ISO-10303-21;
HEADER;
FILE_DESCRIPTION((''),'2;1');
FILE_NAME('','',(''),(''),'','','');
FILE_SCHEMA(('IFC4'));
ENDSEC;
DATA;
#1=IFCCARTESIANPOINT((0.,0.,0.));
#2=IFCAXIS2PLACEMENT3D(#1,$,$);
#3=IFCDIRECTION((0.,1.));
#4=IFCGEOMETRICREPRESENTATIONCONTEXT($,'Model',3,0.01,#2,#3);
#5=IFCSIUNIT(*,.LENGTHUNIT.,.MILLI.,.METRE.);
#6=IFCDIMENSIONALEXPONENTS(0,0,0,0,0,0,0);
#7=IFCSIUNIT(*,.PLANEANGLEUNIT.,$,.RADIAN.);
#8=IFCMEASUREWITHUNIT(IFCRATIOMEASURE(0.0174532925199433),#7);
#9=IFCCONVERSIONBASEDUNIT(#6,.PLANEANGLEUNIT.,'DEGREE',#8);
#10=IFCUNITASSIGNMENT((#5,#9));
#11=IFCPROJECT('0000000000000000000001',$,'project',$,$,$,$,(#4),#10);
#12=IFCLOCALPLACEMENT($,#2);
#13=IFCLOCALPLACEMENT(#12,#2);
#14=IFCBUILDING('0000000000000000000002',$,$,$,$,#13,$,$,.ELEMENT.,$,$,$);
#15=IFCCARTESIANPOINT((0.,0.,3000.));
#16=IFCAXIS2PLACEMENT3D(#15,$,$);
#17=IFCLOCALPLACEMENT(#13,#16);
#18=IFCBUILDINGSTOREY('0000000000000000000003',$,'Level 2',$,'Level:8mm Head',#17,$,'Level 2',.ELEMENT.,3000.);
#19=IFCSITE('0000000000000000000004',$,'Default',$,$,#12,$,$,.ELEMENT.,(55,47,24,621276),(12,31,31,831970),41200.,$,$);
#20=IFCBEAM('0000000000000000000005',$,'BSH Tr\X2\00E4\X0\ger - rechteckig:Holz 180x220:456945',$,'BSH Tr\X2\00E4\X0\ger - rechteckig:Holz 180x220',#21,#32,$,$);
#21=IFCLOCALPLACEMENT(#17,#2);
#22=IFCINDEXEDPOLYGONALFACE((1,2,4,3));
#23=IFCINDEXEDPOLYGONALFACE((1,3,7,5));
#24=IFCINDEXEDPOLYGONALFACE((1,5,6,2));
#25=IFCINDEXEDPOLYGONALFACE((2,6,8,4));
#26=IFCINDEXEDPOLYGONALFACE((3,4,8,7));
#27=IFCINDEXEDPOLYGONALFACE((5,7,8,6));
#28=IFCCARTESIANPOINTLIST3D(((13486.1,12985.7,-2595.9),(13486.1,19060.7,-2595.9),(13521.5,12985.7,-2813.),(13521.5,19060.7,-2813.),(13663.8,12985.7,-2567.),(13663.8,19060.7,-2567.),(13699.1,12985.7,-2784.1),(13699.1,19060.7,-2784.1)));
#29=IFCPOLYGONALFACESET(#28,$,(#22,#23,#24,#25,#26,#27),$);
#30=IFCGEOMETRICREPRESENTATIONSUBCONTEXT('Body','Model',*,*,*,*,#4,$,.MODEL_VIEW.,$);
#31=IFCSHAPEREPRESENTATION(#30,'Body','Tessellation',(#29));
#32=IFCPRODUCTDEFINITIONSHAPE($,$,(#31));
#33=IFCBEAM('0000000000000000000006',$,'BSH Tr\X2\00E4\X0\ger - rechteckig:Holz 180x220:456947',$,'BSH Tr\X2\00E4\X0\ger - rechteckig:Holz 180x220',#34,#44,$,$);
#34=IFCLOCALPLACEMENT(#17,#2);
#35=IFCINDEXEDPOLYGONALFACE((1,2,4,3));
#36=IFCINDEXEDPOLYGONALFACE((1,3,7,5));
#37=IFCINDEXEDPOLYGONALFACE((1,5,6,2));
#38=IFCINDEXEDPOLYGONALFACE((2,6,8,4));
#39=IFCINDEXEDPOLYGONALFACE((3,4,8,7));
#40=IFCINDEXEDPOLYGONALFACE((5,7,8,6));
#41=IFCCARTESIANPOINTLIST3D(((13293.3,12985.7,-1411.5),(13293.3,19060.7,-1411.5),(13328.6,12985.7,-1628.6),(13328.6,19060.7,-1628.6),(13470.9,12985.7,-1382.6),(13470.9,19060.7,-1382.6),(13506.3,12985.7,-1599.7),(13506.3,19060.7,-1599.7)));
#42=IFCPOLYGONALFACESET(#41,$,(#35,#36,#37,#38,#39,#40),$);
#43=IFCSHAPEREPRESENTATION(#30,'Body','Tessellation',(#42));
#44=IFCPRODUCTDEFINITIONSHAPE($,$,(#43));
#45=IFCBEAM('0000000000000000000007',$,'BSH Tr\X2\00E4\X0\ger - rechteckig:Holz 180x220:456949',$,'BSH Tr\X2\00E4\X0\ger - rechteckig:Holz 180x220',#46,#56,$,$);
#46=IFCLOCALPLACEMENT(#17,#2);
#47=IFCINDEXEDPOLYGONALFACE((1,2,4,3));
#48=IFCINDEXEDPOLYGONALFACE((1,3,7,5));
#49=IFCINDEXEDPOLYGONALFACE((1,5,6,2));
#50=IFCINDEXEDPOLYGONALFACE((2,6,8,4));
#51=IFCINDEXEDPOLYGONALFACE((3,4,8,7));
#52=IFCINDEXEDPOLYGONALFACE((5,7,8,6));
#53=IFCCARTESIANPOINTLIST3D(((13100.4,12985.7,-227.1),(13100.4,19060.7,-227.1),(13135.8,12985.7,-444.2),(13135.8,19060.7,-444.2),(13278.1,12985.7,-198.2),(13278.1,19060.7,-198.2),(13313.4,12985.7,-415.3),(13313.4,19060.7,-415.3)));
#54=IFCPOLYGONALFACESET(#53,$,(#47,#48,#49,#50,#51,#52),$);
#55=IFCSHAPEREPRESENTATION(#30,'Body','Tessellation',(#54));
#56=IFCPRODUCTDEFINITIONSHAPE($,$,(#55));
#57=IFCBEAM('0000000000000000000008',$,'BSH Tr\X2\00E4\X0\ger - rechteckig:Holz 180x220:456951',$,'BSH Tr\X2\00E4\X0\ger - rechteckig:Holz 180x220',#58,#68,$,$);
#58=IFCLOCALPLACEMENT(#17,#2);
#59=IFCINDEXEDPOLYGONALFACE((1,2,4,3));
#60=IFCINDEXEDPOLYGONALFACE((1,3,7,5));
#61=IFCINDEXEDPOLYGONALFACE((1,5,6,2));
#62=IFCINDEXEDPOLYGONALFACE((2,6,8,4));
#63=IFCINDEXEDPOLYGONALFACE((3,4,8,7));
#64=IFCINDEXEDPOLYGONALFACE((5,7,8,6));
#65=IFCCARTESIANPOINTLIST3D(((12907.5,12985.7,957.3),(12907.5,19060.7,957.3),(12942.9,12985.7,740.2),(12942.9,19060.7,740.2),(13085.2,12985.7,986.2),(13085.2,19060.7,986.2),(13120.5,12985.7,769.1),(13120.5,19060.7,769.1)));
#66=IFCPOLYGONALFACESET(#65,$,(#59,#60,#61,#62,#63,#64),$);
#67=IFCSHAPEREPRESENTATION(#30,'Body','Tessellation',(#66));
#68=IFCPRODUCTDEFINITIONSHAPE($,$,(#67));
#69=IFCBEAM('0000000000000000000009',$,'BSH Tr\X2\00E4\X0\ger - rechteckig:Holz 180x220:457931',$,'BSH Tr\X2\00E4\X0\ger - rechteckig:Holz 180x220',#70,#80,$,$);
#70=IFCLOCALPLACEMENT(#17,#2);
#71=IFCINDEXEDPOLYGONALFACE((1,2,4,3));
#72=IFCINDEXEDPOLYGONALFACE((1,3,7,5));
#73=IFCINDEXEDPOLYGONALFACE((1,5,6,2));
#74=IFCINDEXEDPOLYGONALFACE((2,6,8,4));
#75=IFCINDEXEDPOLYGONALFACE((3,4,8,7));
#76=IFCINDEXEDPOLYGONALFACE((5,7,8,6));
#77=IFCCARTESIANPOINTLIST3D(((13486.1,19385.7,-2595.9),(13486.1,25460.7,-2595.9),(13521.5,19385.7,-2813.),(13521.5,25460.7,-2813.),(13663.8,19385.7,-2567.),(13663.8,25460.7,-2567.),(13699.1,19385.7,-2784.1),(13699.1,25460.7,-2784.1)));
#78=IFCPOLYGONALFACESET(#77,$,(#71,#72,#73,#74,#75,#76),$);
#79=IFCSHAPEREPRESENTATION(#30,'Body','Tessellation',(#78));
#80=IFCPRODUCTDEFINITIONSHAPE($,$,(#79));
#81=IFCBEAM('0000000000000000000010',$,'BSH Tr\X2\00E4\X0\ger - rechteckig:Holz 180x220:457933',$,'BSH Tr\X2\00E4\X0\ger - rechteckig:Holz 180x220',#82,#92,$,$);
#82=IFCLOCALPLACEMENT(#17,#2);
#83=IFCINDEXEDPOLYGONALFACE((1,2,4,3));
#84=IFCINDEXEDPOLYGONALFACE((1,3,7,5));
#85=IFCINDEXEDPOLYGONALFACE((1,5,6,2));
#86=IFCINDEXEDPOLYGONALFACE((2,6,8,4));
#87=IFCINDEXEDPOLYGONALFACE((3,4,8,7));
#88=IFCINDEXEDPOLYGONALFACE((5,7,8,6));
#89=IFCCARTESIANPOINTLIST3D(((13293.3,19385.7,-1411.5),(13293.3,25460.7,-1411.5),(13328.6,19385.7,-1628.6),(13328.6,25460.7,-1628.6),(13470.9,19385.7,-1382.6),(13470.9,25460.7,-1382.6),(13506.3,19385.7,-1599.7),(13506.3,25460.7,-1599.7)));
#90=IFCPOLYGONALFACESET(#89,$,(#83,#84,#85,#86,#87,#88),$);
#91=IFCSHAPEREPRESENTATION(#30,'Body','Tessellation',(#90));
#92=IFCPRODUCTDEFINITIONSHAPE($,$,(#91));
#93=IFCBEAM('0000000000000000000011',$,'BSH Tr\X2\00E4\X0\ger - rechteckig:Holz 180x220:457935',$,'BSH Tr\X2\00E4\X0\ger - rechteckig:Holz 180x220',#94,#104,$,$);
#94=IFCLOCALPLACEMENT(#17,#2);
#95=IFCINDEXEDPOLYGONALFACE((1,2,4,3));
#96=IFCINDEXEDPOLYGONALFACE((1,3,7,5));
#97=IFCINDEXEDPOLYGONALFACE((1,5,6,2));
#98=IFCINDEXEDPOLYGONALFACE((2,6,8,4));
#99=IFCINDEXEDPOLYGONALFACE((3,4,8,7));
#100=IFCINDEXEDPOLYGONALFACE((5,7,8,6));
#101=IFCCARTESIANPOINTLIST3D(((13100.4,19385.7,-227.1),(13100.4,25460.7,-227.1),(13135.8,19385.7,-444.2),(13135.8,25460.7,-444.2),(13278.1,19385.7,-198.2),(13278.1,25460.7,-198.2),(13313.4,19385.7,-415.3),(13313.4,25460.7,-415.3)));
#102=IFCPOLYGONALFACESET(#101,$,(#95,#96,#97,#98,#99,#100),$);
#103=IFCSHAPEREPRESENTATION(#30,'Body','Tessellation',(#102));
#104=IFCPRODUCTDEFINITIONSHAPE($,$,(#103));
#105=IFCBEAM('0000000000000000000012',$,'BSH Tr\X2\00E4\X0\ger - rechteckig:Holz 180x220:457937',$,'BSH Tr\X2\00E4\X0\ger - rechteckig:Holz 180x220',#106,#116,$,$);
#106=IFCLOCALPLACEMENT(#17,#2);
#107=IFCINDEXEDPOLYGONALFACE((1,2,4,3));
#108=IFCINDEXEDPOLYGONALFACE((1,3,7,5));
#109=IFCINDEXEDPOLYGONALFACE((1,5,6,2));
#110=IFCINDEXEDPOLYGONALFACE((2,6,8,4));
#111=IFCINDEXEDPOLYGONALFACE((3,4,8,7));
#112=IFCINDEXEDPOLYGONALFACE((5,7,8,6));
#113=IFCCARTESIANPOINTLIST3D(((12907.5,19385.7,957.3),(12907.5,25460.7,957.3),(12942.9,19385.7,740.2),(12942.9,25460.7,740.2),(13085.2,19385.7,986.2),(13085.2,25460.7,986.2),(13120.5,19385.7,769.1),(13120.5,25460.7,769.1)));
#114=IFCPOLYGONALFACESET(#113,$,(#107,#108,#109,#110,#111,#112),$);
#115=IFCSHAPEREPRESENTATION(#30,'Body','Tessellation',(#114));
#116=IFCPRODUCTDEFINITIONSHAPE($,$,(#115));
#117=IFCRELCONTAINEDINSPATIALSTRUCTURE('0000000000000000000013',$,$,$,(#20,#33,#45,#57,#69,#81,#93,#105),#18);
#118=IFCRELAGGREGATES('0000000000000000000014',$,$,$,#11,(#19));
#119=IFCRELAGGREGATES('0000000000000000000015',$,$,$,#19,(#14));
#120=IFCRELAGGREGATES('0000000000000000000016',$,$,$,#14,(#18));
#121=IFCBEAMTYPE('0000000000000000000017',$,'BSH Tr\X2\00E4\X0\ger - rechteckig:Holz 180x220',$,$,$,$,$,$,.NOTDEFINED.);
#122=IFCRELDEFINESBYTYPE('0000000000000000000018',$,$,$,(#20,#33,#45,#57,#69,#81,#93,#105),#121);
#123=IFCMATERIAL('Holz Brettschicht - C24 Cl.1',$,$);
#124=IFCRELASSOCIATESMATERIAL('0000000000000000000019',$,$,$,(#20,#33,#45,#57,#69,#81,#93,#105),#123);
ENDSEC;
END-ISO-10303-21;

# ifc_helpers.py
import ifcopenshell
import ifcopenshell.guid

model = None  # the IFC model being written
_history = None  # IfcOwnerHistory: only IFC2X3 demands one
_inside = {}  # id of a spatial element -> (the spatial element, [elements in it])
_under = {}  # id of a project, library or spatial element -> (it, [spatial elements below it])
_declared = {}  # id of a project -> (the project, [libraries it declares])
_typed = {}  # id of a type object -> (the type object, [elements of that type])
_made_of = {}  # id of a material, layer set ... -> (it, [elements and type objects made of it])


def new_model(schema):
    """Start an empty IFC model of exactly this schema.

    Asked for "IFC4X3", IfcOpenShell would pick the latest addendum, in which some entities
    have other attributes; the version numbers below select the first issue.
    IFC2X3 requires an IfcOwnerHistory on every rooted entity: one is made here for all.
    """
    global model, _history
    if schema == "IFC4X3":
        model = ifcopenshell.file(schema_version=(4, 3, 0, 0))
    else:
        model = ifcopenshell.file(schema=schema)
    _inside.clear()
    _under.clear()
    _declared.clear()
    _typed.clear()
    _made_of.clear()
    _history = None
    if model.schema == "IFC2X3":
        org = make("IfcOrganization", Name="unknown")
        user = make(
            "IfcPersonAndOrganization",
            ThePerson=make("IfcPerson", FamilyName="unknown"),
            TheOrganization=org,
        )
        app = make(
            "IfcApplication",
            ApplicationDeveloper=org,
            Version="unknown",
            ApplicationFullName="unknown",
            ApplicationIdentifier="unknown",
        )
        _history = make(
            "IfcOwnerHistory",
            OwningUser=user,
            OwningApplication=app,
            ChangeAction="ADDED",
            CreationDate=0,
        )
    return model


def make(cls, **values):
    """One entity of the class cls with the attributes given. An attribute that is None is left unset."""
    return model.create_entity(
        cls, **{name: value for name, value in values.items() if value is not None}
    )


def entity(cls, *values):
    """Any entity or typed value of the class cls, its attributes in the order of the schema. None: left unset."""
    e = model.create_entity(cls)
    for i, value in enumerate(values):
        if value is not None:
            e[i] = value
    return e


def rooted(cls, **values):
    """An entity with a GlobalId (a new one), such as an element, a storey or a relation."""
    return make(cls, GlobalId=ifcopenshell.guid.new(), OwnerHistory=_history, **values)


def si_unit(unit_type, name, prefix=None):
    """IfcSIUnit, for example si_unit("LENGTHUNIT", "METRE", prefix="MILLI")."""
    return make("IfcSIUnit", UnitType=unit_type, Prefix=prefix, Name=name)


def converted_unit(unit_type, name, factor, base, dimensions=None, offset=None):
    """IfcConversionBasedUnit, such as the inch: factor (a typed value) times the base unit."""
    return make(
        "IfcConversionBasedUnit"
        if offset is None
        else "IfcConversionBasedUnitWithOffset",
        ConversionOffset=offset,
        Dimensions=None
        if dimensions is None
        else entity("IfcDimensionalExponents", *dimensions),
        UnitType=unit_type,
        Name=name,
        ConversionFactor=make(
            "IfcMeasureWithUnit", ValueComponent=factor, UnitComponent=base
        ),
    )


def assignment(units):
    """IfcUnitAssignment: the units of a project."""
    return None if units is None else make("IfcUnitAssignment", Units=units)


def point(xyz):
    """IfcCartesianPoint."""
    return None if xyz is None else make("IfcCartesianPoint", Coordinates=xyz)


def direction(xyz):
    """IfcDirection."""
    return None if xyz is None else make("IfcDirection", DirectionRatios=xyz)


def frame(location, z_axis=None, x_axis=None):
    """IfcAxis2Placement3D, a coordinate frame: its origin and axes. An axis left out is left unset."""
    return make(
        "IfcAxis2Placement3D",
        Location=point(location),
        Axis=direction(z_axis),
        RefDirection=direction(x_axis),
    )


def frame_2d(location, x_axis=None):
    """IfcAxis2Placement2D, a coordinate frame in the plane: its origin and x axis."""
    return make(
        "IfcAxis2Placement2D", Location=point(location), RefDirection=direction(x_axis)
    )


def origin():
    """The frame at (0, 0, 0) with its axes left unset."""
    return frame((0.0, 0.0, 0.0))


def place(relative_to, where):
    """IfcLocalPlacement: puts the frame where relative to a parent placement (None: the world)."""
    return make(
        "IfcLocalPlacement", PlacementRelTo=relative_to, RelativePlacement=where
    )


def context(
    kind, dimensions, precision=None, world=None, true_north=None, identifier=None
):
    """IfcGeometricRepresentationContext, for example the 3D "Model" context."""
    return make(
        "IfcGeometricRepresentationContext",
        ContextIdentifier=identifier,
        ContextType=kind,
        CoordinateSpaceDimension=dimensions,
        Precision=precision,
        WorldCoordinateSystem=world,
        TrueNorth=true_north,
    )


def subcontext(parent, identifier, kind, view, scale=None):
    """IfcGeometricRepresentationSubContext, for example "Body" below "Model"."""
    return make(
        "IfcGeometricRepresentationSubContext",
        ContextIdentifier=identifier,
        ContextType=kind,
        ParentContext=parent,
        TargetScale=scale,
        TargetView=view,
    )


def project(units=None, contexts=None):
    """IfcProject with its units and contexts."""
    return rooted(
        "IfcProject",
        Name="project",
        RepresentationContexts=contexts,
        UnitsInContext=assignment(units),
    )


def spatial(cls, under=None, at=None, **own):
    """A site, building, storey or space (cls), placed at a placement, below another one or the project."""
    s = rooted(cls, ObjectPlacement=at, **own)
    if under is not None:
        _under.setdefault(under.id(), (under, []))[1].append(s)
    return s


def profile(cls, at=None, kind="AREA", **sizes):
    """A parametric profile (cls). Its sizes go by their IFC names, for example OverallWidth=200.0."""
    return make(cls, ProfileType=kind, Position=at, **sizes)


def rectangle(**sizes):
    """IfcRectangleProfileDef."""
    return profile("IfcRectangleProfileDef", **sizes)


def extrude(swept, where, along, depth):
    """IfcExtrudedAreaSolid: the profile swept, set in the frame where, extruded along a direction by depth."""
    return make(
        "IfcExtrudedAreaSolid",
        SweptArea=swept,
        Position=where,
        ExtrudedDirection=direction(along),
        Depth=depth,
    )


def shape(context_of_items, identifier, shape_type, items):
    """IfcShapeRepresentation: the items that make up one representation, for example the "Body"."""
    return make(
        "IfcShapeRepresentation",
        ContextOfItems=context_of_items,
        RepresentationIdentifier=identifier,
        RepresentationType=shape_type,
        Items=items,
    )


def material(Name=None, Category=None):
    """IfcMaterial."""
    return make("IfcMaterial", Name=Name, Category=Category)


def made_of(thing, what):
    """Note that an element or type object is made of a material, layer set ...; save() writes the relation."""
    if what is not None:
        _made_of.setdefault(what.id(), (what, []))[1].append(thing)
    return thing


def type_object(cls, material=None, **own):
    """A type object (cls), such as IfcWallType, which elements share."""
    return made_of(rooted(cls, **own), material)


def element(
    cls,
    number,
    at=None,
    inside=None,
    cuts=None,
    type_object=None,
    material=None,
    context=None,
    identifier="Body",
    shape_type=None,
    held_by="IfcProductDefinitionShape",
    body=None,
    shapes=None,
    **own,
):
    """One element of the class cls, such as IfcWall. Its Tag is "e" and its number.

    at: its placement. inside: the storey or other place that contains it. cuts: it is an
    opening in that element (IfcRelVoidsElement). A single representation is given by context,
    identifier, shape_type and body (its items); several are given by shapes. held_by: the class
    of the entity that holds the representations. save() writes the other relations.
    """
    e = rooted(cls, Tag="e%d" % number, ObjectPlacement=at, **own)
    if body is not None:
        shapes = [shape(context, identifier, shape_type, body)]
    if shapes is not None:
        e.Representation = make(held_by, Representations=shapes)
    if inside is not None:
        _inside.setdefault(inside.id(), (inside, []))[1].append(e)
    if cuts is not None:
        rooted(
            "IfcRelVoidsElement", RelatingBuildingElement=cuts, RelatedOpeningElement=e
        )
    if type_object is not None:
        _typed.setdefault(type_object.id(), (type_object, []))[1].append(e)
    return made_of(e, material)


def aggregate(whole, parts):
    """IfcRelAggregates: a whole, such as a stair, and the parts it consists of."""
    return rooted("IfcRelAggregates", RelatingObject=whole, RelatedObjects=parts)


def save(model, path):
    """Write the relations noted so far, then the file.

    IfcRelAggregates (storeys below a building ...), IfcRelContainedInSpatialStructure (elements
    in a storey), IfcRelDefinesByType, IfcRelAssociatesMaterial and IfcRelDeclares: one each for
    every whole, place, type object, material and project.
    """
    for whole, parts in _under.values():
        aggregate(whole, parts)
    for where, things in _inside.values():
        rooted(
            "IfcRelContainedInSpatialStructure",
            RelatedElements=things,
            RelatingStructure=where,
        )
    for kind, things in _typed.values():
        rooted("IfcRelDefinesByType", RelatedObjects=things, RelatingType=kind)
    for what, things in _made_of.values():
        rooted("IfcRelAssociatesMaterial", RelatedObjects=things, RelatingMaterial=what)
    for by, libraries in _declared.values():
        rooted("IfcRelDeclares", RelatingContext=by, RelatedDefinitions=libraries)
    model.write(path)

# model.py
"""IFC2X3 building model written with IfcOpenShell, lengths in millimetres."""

from ifc_helpers import new_model, entity, si_unit, converted_unit, direction, frame, frame_2d, origin, place, context, subcontext, project, spatial, rectangle, extrude, material, type_object, element, save


model = new_model("IFC2X3")

# Units and contexts
model_context = context("Model", 3, precision=0.01, world=origin(), true_north=direction((0.0, 1.0)))
body_context = subcontext(model_context, "Body", "Model", "MODEL_VIEW")
ifc_project = project(units=[si_unit("LENGTHUNIT", "METRE", prefix="MILLI"), converted_unit("PLANEANGLEUNIT", "DEGREE", entity("IfcRatioMeasure", 0.0174532925199433), si_unit("PLANEANGLEUNIT", "RADIAN"), dimensions=[0, 0, 0, 0, 0, 0, 0])], contexts=[model_context])

# Site, building, storey
site_placement = place(None, origin())
site = spatial("IfcSite", under=ifc_project, at=site_placement, Name="Default", CompositionType="ELEMENT", RefLatitude=(55, 47, 24, 621276), RefLongitude=(12, 31, 31, 831970), RefElevation=41200.0)
building_placement = place(site_placement, origin())
building = spatial("IfcBuilding", under=site, at=building_placement, CompositionType="ELEMENT")
storey_placement = place(building_placement, frame((0.0, 0.0, 3000.0)))
storey = spatial("IfcBuildingStorey", under=building, at=storey_placement, Name="Level 2", ObjectType="Level:8mm Head", LongName="Level 2", CompositionType="ELEMENT", Elevation=3000.0)

# Beams
ifc_material = material(Name="Holz Brettschicht - C24 Cl.1")
beam_type_1 = type_object("IfcBeamType", Name="BSH Träger - rechteckig:Holz 180x220", PredefinedType="NOTDEFINED")
beam_1_placement = place(storey_placement, frame((13681.5, 13723.2, -2675.5), z_axis=(0.0, 0.0, 1.0), x_axis=(0.0, 1.0, 0.0)))
element("IfcBeam", 1, at=beam_1_placement, inside=storey, type_object=beam_type_1, material=ifc_material, Name="BSH Träger - rechteckig:Holz 180x220:456945", ObjectType="BSH Träger - rechteckig:Holz 180x220", context=body_context, shape_type="SweptSolid", body=[
    extrude(rectangle(XDim=220.0, YDim=180.0, at=frame_2d((0.0, 0.0), x_axis=(1.0, 0.0))), frame((-737.5, 88.8, -14.5), z_axis=(1.0, 0.0, 0.0), x_axis=(0.0, 0.160724, 0.986999)), (0.0, 0.0, 1.0), 6075.0),
])
beam_2_placement = place(storey_placement, frame((13488.6, 13723.2, -1491.1), z_axis=(0.0, 0.0, 1.0), x_axis=(0.0, 1.0, 0.0)))
element("IfcBeam", 2, at=beam_2_placement, inside=storey, type_object=beam_type_1, material=ifc_material, Name="BSH Träger - rechteckig:Holz 180x220:456947", ObjectType="BSH Träger - rechteckig:Holz 180x220", context=body_context, shape_type="SweptSolid", body=[
    extrude(rectangle(XDim=220.0, YDim=180.0, at=frame_2d((0.0, 0.0), x_axis=(1.0, 0.0))), frame((-737.5, 88.8, -14.5), z_axis=(1.0, 0.0, 0.0), x_axis=(0.0, 0.160724, 0.986999)), (0.0, 0.0, 1.0), 6075.0),
])
beam_3_placement = place(storey_placement, frame((13295.7, 13723.2, -306.7), z_axis=(0.0, 0.0, 1.0), x_axis=(0.0, 1.0, 0.0)))
element("IfcBeam", 3, at=beam_3_placement, inside=storey, type_object=beam_type_1, material=ifc_material, Name="BSH Träger - rechteckig:Holz 180x220:456949", ObjectType="BSH Träger - rechteckig:Holz 180x220", context=body_context, shape_type="SweptSolid", body=[
    extrude(rectangle(XDim=220.0, YDim=180.0, at=frame_2d((0.0, 0.0), x_axis=(1.0, 0.0))), frame((-737.5, 88.8, -14.5), z_axis=(1.0, 0.0, 0.0), x_axis=(0.0, 0.160724, 0.986999)), (0.0, 0.0, 1.0), 6075.0),
])
beam_4_placement = place(storey_placement, frame((13102.9, 13723.2, 877.7), z_axis=(0.0, 0.0, 1.0), x_axis=(0.0, 1.0, 0.0)))
element("IfcBeam", 4, at=beam_4_placement, inside=storey, type_object=beam_type_1, material=ifc_material, Name="BSH Träger - rechteckig:Holz 180x220:456951", ObjectType="BSH Träger - rechteckig:Holz 180x220", context=body_context, shape_type="SweptSolid", body=[
    extrude(rectangle(XDim=220.0, YDim=180.0, at=frame_2d((0.0, 0.0), x_axis=(1.0, 0.0))), frame((-737.5, 88.8, -14.5), z_axis=(1.0, 0.0, 0.0), x_axis=(0.0, 0.160724, 0.986999)), (0.0, 0.0, 1.0), 6075.0),
])
beam_5_placement = place(storey_placement, frame((13681.5, 20123.2, -2675.5), z_axis=(0.0, 0.0, 1.0), x_axis=(0.0, 1.0, 0.0)))
element("IfcBeam", 5, at=beam_5_placement, inside=storey, type_object=beam_type_1, material=ifc_material, Name="BSH Träger - rechteckig:Holz 180x220:457931", ObjectType="BSH Träger - rechteckig:Holz 180x220", context=body_context, shape_type="SweptSolid", body=[
    extrude(rectangle(XDim=220.0, YDim=180.0, at=frame_2d((0.0, 0.0), x_axis=(1.0, 0.0))), frame((-737.5, 88.8, -14.5), z_axis=(1.0, 0.0, 0.0), x_axis=(0.0, 0.160724, 0.986999)), (0.0, 0.0, 1.0), 6075.0),
])
beam_6_placement = place(storey_placement, frame((13488.6, 20123.2, -1491.1), z_axis=(0.0, 0.0, 1.0), x_axis=(0.0, 1.0, 0.0)))
element("IfcBeam", 6, at=beam_6_placement, inside=storey, type_object=beam_type_1, material=ifc_material, Name="BSH Träger - rechteckig:Holz 180x220:457933", ObjectType="BSH Träger - rechteckig:Holz 180x220", context=body_context, shape_type="SweptSolid", body=[
    extrude(rectangle(XDim=220.0, YDim=180.0, at=frame_2d((0.0, 0.0), x_axis=(1.0, 0.0))), frame((-737.5, 88.8, -14.5), z_axis=(1.0, 0.0, 0.0), x_axis=(0.0, 0.160724, 0.986999)), (0.0, 0.0, 1.0), 6075.0),
])
beam_7_placement = place(storey_placement, frame((13295.7, 20123.2, -306.7), z_axis=(0.0, 0.0, 1.0), x_axis=(0.0, 1.0, 0.0)))
element("IfcBeam", 7, at=beam_7_placement, inside=storey, type_object=beam_type_1, material=ifc_material, Name="BSH Träger - rechteckig:Holz 180x220:457935", ObjectType="BSH Träger - rechteckig:Holz 180x220", context=body_context, shape_type="SweptSolid", body=[
    extrude(rectangle(XDim=220.0, YDim=180.0, at=frame_2d((0.0, 0.0), x_axis=(1.0, 0.0))), frame((-737.5, 88.8, -14.5), z_axis=(1.0, 0.0, 0.0), x_axis=(0.0, 0.160724, 0.986999)), (0.0, 0.0, 1.0), 6075.0),
])
beam_8_placement = place(storey_placement, frame((13102.9, 20123.2, 877.7), z_axis=(0.0, 0.0, 1.0), x_axis=(0.0, 1.0, 0.0)))
element("IfcBeam", 8, at=beam_8_placement, inside=storey, type_object=beam_type_1, material=ifc_material, Name="BSH Träger - rechteckig:Holz 180x220:457937", ObjectType="BSH Träger - rechteckig:Holz 180x220", context=body_context, shape_type="SweptSolid", body=[
    extrude(rectangle(XDim=220.0, YDim=180.0, at=frame_2d((0.0, 0.0), x_axis=(1.0, 0.0))), frame((-737.5, 88.8, -14.5), z_axis=(1.0, 0.0, 0.0), x_axis=(0.0, 0.160724, 0.986999)), (0.0, 0.0, 1.0), 6075.0),
])

save(model, "model.ifc")
